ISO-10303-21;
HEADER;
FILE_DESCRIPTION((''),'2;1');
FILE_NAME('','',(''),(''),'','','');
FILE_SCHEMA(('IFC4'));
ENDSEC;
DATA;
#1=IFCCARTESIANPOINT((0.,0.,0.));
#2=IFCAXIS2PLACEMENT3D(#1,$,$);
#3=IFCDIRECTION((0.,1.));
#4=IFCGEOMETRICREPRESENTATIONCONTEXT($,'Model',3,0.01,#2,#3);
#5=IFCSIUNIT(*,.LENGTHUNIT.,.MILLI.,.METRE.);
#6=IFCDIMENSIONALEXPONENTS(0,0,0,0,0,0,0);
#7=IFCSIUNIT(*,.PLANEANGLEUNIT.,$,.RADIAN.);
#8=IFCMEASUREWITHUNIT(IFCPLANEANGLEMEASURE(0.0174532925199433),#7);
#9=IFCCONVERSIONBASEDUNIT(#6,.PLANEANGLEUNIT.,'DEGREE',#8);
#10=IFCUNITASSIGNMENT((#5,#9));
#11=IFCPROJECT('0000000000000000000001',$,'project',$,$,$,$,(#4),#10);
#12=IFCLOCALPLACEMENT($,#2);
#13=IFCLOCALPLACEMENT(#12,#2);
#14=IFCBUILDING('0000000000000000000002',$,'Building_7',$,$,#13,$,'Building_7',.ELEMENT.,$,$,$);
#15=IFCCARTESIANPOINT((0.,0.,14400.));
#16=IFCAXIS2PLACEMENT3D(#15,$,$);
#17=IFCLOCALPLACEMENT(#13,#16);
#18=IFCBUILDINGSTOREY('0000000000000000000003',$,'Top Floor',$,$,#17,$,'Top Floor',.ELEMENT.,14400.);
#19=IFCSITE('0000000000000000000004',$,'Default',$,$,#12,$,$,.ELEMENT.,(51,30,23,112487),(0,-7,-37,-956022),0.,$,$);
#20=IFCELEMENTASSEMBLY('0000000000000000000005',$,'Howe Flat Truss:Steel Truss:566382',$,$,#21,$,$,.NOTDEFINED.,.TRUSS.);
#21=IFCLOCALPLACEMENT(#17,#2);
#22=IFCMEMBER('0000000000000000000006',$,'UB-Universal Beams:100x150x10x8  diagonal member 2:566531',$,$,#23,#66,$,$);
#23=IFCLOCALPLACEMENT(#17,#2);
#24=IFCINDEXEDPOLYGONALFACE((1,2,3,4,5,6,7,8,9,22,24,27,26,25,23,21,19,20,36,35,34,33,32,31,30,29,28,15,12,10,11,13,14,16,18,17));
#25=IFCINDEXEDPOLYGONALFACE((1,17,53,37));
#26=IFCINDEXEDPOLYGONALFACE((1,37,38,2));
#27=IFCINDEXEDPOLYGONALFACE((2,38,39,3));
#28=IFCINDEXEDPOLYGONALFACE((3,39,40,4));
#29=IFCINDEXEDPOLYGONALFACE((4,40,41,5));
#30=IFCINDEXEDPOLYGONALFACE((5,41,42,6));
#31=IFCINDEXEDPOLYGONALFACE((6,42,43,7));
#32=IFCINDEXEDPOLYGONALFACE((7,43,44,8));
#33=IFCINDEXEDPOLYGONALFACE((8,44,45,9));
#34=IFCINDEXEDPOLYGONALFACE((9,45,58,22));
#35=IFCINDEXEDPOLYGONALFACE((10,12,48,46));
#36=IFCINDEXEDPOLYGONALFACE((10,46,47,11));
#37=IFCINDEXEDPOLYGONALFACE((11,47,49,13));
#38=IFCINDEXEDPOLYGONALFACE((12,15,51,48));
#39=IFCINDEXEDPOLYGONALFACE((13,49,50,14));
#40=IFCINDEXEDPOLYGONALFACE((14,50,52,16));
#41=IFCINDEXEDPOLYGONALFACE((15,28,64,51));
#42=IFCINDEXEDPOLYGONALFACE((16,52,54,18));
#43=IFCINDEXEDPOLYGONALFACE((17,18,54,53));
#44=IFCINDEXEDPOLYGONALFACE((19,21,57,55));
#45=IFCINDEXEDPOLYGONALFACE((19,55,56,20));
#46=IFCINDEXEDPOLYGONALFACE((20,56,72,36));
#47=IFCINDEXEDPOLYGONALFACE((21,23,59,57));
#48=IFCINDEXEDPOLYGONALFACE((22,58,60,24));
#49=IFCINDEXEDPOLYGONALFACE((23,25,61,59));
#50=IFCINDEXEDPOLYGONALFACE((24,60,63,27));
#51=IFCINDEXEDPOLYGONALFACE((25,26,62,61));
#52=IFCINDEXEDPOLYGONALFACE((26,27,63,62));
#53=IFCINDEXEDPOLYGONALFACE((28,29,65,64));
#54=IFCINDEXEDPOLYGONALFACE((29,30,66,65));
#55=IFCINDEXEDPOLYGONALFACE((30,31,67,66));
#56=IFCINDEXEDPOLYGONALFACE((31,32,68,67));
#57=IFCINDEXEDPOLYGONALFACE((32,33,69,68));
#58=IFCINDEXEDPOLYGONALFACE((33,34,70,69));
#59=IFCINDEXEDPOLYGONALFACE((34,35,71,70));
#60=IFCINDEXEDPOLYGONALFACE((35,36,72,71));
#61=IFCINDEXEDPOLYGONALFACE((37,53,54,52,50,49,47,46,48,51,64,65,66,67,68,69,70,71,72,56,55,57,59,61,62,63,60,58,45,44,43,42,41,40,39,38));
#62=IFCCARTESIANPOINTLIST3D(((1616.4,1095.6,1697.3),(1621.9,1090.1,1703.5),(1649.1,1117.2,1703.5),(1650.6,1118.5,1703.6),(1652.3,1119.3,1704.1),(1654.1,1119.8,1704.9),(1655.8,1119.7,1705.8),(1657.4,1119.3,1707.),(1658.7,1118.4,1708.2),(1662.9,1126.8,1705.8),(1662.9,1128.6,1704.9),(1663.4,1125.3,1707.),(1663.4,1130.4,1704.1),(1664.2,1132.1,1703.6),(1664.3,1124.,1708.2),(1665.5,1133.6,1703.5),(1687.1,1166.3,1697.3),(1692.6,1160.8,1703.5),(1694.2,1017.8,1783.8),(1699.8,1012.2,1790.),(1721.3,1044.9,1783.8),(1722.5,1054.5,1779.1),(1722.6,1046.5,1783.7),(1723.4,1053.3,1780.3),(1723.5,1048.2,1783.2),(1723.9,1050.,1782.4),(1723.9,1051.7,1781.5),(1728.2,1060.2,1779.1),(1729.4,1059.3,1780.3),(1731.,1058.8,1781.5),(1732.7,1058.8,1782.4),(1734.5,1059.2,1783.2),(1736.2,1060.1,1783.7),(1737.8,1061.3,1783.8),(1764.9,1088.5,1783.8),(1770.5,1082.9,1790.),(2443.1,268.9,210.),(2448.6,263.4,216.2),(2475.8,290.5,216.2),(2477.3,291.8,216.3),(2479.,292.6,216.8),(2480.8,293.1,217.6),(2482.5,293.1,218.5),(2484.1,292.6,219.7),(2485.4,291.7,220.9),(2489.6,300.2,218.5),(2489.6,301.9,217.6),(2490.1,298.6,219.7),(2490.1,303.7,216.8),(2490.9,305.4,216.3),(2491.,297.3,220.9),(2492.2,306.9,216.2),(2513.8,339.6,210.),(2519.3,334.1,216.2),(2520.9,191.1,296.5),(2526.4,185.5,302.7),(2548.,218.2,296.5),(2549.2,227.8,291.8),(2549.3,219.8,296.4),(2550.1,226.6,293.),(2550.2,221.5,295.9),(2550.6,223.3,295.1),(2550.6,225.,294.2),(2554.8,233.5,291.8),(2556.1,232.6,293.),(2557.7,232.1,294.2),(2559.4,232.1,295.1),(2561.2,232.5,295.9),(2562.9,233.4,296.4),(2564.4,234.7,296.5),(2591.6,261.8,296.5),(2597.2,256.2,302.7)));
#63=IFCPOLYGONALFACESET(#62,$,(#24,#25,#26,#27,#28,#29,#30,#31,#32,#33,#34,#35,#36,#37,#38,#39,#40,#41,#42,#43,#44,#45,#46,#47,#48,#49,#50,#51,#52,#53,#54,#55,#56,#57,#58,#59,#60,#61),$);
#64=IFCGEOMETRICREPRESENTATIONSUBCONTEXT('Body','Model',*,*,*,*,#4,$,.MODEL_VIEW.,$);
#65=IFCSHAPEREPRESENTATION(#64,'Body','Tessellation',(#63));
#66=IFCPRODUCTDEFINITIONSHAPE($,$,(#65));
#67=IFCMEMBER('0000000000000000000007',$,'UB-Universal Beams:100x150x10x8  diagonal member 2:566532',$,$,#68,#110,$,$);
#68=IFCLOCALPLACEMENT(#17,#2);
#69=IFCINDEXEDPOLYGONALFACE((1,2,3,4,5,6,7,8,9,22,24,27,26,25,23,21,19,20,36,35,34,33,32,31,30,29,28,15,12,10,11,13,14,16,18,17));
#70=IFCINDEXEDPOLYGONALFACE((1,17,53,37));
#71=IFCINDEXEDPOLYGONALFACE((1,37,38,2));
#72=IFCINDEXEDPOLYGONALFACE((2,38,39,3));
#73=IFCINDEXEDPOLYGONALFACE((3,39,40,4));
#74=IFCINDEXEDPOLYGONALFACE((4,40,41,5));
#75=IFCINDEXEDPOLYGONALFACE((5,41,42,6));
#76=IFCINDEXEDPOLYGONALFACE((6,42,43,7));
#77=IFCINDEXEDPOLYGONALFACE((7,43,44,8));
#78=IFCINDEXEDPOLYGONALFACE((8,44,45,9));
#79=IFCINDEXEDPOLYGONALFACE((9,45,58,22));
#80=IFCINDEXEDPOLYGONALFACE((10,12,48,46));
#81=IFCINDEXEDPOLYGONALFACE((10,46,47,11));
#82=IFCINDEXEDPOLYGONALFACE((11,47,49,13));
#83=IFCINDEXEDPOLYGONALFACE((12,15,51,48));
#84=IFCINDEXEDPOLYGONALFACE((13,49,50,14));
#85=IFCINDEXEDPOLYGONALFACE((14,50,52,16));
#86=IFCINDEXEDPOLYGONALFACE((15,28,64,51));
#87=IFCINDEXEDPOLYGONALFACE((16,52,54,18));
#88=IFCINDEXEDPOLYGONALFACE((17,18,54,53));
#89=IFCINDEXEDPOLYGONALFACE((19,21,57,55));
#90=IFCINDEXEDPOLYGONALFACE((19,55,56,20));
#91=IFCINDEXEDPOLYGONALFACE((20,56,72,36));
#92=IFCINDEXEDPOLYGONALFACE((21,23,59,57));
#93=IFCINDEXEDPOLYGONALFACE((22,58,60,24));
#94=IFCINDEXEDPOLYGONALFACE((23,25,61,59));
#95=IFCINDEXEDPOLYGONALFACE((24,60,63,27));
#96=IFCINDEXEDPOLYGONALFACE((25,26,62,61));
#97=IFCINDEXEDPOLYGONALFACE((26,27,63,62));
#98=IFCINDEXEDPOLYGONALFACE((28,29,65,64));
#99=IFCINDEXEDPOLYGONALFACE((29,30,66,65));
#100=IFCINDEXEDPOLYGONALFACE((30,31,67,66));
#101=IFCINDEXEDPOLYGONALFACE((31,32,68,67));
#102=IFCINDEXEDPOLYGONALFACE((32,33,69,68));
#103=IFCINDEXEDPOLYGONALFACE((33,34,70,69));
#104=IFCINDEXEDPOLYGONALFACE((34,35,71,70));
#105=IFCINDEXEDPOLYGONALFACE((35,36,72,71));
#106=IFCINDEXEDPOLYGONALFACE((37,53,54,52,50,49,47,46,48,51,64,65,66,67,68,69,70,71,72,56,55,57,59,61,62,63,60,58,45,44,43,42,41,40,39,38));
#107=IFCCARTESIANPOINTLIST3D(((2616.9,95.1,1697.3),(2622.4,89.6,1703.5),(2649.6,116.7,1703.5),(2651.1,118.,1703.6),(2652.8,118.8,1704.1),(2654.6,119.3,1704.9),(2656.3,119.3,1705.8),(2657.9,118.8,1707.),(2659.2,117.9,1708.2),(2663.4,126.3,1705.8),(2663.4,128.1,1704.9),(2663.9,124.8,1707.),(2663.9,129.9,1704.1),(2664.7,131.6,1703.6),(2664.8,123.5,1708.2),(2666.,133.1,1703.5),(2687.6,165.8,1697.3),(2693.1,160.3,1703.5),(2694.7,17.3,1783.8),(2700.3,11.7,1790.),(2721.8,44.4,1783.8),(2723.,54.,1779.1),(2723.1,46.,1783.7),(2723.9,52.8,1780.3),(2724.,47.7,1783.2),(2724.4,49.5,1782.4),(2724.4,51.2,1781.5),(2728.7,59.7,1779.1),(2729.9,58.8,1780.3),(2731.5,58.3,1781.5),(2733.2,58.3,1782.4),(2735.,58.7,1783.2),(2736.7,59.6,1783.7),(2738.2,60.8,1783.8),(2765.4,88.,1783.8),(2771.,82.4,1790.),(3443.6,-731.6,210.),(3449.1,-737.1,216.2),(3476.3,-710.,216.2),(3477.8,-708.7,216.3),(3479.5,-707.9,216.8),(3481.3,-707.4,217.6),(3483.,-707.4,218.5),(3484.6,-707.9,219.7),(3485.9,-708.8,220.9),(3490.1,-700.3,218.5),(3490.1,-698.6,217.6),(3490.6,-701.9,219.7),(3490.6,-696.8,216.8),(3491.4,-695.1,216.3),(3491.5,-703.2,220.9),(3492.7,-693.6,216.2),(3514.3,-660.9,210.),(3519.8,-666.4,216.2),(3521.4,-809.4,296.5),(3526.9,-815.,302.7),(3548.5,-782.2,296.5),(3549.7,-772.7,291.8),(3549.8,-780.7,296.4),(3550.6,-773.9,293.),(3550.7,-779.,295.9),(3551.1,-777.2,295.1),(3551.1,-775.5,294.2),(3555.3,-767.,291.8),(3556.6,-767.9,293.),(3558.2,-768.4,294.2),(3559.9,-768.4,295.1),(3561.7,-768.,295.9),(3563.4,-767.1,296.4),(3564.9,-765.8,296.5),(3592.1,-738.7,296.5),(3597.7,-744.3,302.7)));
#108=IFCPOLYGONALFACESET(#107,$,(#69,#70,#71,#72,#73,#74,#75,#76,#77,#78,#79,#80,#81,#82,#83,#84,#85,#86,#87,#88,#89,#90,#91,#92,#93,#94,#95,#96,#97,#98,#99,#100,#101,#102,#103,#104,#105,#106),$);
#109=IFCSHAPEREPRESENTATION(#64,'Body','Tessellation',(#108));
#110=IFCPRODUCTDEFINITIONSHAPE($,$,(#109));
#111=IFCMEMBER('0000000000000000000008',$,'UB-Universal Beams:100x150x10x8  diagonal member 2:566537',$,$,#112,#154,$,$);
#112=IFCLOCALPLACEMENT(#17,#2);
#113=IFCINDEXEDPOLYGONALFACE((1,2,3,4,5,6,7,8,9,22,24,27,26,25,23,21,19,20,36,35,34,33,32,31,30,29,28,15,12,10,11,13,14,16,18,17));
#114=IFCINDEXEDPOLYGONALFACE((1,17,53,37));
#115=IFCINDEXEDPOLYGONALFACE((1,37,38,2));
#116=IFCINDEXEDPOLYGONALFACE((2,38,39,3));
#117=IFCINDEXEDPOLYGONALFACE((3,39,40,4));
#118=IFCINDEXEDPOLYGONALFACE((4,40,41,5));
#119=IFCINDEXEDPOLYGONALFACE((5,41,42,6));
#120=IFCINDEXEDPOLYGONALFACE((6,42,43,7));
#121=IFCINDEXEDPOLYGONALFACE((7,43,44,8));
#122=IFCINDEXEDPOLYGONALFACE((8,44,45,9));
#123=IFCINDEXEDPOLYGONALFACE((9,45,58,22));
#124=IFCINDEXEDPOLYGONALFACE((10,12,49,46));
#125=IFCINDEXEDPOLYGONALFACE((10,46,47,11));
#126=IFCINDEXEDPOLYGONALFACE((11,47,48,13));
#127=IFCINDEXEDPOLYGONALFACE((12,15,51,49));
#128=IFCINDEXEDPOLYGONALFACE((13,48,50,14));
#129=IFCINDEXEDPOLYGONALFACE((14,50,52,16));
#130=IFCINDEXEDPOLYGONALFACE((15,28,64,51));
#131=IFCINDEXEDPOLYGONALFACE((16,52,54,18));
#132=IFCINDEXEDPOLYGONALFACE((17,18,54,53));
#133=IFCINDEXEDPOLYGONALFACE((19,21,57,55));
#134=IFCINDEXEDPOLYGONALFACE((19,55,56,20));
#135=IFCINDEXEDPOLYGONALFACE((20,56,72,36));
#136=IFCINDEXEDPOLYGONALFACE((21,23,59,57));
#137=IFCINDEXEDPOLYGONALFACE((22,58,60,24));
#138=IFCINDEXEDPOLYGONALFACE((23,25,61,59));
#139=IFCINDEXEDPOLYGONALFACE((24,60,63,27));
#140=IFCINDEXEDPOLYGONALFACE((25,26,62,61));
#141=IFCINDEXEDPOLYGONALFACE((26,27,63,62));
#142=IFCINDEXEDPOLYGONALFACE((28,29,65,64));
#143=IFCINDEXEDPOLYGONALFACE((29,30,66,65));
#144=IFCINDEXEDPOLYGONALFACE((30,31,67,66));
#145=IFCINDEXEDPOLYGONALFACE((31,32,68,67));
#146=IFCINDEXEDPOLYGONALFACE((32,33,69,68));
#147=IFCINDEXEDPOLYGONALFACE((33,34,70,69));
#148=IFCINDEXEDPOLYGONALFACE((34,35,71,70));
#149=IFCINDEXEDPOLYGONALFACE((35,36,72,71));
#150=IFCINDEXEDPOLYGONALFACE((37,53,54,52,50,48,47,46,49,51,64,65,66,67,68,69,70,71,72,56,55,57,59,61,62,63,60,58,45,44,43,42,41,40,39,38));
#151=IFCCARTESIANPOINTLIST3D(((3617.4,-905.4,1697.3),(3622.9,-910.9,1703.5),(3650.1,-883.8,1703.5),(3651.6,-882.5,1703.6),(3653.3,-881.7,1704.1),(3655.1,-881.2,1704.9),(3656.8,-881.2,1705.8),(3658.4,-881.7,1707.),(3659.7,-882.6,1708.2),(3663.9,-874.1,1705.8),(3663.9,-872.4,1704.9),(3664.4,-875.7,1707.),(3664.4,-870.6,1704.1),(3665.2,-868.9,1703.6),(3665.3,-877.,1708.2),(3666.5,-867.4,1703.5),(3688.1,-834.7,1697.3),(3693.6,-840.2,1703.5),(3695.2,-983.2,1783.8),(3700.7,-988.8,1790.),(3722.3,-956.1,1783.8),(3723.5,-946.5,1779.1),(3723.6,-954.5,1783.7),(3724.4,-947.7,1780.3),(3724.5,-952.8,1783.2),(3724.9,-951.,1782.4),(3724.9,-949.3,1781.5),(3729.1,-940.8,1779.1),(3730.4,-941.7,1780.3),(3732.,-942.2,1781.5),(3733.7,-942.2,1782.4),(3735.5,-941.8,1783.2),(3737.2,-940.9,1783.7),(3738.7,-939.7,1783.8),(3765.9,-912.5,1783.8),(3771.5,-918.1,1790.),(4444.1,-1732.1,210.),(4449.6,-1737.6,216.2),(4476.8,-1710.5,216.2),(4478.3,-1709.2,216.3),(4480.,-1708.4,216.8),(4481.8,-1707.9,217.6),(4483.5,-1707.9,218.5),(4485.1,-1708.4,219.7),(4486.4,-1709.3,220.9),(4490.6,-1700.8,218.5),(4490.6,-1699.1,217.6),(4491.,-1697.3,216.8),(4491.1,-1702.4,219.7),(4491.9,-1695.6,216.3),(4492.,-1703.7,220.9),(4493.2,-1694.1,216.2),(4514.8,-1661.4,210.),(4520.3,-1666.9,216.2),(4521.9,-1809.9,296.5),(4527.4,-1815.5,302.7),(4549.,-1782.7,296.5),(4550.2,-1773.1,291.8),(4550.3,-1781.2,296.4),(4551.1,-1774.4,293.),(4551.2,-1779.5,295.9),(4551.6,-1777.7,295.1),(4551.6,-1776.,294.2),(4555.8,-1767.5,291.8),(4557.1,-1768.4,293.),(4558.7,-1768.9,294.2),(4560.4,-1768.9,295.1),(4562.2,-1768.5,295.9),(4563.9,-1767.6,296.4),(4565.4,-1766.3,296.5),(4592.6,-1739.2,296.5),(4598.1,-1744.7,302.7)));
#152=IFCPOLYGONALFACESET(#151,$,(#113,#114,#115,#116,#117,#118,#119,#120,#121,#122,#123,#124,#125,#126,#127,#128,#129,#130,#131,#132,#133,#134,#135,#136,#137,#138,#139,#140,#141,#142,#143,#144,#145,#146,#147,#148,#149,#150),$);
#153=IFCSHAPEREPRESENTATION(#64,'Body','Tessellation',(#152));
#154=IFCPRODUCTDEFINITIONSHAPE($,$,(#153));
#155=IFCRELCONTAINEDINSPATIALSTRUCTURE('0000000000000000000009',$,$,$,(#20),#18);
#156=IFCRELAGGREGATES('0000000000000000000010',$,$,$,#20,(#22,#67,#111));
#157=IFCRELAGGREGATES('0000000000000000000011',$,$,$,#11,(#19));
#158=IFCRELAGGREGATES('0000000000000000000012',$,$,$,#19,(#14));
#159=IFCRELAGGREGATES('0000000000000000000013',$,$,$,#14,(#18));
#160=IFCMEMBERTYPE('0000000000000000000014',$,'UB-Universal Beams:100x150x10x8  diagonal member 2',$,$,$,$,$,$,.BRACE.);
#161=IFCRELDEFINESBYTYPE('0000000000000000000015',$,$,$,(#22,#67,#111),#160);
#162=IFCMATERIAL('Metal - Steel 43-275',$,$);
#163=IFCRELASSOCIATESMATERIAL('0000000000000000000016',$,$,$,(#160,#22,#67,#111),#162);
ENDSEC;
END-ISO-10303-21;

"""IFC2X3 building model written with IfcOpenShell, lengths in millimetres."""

from ifc_helpers import new_model, entity, si_unit, converted_unit, direction, frame, frame_2d, origin, place, context, subcontext, project, spatial, polyline, circle_curve, parameter, trimmed, segment, composite_curve, outline, extrude, source, transform, mapped, material, type_object, type_shapes, element, aggregate, save


model = new_model("IFC2X3")

# Units and contexts
model_context = context("Model", 3, precision=0.01, world=origin(), true_north=direction((0.0, 1.0)))
body_context = subcontext(model_context, "Body", "Model", "MODEL_VIEW")
ifc_project = project(units=[si_unit("LENGTHUNIT", "METRE", prefix="MILLI"), converted_unit("PLANEANGLEUNIT", "DEGREE", entity("IfcPlaneAngleMeasure", 0.0174532925199433), si_unit("PLANEANGLEUNIT", "RADIAN"), dimensions=[0, 0, 0, 0, 0, 0, 0])], contexts=[model_context])

# Site, building, storey
site_placement = place(None, origin())
site = spatial("IfcSite", under=ifc_project, at=site_placement, Name="Default", CompositionType="ELEMENT", RefLatitude=(51, 30, 23, 112487), RefLongitude=(0, -7, -37, -956022), RefElevation=0.0)
building_placement = place(site_placement, origin())
building = spatial("IfcBuilding", under=site, at=building_placement, Name="Building_7", LongName="Building_7", CompositionType="ELEMENT")
storey_placement = place(building_placement, frame((0.0, 0.0, 14400.0)))
storey = spatial("IfcBuildingStorey", under=building, at=storey_placement, Name="Top Floor", LongName="Top Floor", CompositionType="ELEMENT", Elevation=14400.0)

# Shared definitions
ifc_material = material(Name="Metal - Steel 43-275")

# Element assembly
assembly_1_placement = place(storey_placement, origin())
assembly_1 = element("IfcElementAssembly", 1, at=assembly_1_placement, inside=storey, Name="Howe Flat Truss:Steel Truss:566382", AssemblyPlace="NOTDEFINED", PredefinedType="TRUSS")

# Members
member_type_1 = type_object("IfcMemberType", Name="UB-Universal Beams:100x150x10x8  diagonal member 2", PredefinedType="BRACE", material=ifc_material)
shared_shape_1 = source(origin(), body_context, "Body", "SweptSolid", [
    extrude(outline(composite_curve([segment(polyline([(-50.0, -65.0), (-50.0, -75.0)]), True, "CONTINUOUS"), segment(polyline([(-50.0, -75.0), (50.0, -75.0)]), True, "CONTINUOUS"), segment(polyline([(50.0, -75.0), (50.0, -65.0)]), True, "CONTINUOUS"), segment(polyline([(50.0, -65.0), (11.6, -65.0)]), True, "CONTINUOUS"), segment(trimmed(circle_curve(frame_2d((11.6, -57.4), x_axis=(1.0, 0.0)), 7.6), [parameter(180.0)], [parameter(270.0)], True, "PARAMETER"), False, "CONTINUOUS"), segment(polyline([(4.0, -57.4), (4.0, 57.4)]), True, "CONTINUOUS"), segment(trimmed(circle_curve(frame_2d((11.6, 57.4), x_axis=(1.0, 0.0)), 7.6), [parameter(90.0)], [parameter(180.0)], True, "PARAMETER"), False, "CONTINUOUS"), segment(polyline([(11.6, 65.0), (50.0, 65.0)]), True, "CONTINUOUS"), segment(polyline([(50.0, 65.0), (50.0, 75.0)]), True, "CONTINUOUS"), segment(polyline([(50.0, 75.0), (-50.0, 75.0)]), True, "CONTINUOUS"), segment(polyline([(-50.0, 75.0), (-50.0, 65.0)]), True, "CONTINUOUS"), segment(polyline([(-50.0, 65.0), (-11.6, 65.0)]), True, "CONTINUOUS"), segment(trimmed(circle_curve(frame_2d((-11.6, 57.4), x_axis=(1.0, 0.0)), 7.6), [parameter(360.0)], [parameter(90.0)], True, "PARAMETER"), False, "CONTINUOUS"), segment(polyline([(-4.0, 57.4), (-4.0, -57.4)]), True, "CONTINUOUS"), segment(trimmed(circle_curve(frame_2d((-11.6, -57.4), x_axis=(1.0, 0.0)), 7.6), [parameter(270.0)], [parameter(360.0)], True, "PARAMETER"), False, "CONTINUOUS"), segment(polyline([(-11.6, -65.0), (-50.0, -65.0)]), True, "CONTINUOUS")], self_intersect=False)), frame((-945.9, 0.0, 0.0), z_axis=(-1.0, 0.0, 0.0), x_axis=(0.0, -1.0, 0.0)), (0.0, 0.0, -1.0), 1891.8),
])
type_shapes(member_type_1, [shared_shape_1])
member_1_placement = place(assembly_1_placement, frame((2106.8, 675.9, 1000.0), z_axis=(-0.555916, 0.555916, -0.617992), x_axis=(-0.436986, 0.436986, 0.786184)))
member_1 = element("IfcMember", 2, at=member_1_placement, type_object=member_type_1, material=ifc_material, Name="UB-Universal Beams:100x150x10x8  diagonal member 2:566531", context=body_context, shape_type="MappedRepresentation", body=[
    mapped(shared_shape_1, transform((0.0, 0.0, 0.0), scale=1.0)),
])
member_2_placement = place(assembly_1_placement, frame((3107.3, -324.6, 1000.0), z_axis=(-0.555916, 0.555916, -0.617992), x_axis=(-0.436986, 0.436986, 0.786184)))
member_2 = element("IfcMember", 3, at=member_2_placement, type_object=member_type_1, material=ifc_material, Name="UB-Universal Beams:100x150x10x8  diagonal member 2:566532", context=body_context, shape_type="MappedRepresentation", body=[
    mapped(shared_shape_1, transform((0.0, 0.0, 0.0), scale=1.0)),
])
member_3_placement = place(assembly_1_placement, frame((4107.8, -1325.1, 1000.0), z_axis=(-0.555916, 0.555916, -0.617992), x_axis=(-0.436986, 0.436986, 0.786184)))
member_3 = element("IfcMember", 4, at=member_3_placement, type_object=member_type_1, material=ifc_material, Name="UB-Universal Beams:100x150x10x8  diagonal member 2:566537", context=body_context, shape_type="MappedRepresentation", body=[
    mapped(shared_shape_1, transform((0.0, 0.0, 0.0), scale=1.0)),
])
aggregate(assembly_1, [member_1, member_2, member_3])

save(model, "model.ifc")
